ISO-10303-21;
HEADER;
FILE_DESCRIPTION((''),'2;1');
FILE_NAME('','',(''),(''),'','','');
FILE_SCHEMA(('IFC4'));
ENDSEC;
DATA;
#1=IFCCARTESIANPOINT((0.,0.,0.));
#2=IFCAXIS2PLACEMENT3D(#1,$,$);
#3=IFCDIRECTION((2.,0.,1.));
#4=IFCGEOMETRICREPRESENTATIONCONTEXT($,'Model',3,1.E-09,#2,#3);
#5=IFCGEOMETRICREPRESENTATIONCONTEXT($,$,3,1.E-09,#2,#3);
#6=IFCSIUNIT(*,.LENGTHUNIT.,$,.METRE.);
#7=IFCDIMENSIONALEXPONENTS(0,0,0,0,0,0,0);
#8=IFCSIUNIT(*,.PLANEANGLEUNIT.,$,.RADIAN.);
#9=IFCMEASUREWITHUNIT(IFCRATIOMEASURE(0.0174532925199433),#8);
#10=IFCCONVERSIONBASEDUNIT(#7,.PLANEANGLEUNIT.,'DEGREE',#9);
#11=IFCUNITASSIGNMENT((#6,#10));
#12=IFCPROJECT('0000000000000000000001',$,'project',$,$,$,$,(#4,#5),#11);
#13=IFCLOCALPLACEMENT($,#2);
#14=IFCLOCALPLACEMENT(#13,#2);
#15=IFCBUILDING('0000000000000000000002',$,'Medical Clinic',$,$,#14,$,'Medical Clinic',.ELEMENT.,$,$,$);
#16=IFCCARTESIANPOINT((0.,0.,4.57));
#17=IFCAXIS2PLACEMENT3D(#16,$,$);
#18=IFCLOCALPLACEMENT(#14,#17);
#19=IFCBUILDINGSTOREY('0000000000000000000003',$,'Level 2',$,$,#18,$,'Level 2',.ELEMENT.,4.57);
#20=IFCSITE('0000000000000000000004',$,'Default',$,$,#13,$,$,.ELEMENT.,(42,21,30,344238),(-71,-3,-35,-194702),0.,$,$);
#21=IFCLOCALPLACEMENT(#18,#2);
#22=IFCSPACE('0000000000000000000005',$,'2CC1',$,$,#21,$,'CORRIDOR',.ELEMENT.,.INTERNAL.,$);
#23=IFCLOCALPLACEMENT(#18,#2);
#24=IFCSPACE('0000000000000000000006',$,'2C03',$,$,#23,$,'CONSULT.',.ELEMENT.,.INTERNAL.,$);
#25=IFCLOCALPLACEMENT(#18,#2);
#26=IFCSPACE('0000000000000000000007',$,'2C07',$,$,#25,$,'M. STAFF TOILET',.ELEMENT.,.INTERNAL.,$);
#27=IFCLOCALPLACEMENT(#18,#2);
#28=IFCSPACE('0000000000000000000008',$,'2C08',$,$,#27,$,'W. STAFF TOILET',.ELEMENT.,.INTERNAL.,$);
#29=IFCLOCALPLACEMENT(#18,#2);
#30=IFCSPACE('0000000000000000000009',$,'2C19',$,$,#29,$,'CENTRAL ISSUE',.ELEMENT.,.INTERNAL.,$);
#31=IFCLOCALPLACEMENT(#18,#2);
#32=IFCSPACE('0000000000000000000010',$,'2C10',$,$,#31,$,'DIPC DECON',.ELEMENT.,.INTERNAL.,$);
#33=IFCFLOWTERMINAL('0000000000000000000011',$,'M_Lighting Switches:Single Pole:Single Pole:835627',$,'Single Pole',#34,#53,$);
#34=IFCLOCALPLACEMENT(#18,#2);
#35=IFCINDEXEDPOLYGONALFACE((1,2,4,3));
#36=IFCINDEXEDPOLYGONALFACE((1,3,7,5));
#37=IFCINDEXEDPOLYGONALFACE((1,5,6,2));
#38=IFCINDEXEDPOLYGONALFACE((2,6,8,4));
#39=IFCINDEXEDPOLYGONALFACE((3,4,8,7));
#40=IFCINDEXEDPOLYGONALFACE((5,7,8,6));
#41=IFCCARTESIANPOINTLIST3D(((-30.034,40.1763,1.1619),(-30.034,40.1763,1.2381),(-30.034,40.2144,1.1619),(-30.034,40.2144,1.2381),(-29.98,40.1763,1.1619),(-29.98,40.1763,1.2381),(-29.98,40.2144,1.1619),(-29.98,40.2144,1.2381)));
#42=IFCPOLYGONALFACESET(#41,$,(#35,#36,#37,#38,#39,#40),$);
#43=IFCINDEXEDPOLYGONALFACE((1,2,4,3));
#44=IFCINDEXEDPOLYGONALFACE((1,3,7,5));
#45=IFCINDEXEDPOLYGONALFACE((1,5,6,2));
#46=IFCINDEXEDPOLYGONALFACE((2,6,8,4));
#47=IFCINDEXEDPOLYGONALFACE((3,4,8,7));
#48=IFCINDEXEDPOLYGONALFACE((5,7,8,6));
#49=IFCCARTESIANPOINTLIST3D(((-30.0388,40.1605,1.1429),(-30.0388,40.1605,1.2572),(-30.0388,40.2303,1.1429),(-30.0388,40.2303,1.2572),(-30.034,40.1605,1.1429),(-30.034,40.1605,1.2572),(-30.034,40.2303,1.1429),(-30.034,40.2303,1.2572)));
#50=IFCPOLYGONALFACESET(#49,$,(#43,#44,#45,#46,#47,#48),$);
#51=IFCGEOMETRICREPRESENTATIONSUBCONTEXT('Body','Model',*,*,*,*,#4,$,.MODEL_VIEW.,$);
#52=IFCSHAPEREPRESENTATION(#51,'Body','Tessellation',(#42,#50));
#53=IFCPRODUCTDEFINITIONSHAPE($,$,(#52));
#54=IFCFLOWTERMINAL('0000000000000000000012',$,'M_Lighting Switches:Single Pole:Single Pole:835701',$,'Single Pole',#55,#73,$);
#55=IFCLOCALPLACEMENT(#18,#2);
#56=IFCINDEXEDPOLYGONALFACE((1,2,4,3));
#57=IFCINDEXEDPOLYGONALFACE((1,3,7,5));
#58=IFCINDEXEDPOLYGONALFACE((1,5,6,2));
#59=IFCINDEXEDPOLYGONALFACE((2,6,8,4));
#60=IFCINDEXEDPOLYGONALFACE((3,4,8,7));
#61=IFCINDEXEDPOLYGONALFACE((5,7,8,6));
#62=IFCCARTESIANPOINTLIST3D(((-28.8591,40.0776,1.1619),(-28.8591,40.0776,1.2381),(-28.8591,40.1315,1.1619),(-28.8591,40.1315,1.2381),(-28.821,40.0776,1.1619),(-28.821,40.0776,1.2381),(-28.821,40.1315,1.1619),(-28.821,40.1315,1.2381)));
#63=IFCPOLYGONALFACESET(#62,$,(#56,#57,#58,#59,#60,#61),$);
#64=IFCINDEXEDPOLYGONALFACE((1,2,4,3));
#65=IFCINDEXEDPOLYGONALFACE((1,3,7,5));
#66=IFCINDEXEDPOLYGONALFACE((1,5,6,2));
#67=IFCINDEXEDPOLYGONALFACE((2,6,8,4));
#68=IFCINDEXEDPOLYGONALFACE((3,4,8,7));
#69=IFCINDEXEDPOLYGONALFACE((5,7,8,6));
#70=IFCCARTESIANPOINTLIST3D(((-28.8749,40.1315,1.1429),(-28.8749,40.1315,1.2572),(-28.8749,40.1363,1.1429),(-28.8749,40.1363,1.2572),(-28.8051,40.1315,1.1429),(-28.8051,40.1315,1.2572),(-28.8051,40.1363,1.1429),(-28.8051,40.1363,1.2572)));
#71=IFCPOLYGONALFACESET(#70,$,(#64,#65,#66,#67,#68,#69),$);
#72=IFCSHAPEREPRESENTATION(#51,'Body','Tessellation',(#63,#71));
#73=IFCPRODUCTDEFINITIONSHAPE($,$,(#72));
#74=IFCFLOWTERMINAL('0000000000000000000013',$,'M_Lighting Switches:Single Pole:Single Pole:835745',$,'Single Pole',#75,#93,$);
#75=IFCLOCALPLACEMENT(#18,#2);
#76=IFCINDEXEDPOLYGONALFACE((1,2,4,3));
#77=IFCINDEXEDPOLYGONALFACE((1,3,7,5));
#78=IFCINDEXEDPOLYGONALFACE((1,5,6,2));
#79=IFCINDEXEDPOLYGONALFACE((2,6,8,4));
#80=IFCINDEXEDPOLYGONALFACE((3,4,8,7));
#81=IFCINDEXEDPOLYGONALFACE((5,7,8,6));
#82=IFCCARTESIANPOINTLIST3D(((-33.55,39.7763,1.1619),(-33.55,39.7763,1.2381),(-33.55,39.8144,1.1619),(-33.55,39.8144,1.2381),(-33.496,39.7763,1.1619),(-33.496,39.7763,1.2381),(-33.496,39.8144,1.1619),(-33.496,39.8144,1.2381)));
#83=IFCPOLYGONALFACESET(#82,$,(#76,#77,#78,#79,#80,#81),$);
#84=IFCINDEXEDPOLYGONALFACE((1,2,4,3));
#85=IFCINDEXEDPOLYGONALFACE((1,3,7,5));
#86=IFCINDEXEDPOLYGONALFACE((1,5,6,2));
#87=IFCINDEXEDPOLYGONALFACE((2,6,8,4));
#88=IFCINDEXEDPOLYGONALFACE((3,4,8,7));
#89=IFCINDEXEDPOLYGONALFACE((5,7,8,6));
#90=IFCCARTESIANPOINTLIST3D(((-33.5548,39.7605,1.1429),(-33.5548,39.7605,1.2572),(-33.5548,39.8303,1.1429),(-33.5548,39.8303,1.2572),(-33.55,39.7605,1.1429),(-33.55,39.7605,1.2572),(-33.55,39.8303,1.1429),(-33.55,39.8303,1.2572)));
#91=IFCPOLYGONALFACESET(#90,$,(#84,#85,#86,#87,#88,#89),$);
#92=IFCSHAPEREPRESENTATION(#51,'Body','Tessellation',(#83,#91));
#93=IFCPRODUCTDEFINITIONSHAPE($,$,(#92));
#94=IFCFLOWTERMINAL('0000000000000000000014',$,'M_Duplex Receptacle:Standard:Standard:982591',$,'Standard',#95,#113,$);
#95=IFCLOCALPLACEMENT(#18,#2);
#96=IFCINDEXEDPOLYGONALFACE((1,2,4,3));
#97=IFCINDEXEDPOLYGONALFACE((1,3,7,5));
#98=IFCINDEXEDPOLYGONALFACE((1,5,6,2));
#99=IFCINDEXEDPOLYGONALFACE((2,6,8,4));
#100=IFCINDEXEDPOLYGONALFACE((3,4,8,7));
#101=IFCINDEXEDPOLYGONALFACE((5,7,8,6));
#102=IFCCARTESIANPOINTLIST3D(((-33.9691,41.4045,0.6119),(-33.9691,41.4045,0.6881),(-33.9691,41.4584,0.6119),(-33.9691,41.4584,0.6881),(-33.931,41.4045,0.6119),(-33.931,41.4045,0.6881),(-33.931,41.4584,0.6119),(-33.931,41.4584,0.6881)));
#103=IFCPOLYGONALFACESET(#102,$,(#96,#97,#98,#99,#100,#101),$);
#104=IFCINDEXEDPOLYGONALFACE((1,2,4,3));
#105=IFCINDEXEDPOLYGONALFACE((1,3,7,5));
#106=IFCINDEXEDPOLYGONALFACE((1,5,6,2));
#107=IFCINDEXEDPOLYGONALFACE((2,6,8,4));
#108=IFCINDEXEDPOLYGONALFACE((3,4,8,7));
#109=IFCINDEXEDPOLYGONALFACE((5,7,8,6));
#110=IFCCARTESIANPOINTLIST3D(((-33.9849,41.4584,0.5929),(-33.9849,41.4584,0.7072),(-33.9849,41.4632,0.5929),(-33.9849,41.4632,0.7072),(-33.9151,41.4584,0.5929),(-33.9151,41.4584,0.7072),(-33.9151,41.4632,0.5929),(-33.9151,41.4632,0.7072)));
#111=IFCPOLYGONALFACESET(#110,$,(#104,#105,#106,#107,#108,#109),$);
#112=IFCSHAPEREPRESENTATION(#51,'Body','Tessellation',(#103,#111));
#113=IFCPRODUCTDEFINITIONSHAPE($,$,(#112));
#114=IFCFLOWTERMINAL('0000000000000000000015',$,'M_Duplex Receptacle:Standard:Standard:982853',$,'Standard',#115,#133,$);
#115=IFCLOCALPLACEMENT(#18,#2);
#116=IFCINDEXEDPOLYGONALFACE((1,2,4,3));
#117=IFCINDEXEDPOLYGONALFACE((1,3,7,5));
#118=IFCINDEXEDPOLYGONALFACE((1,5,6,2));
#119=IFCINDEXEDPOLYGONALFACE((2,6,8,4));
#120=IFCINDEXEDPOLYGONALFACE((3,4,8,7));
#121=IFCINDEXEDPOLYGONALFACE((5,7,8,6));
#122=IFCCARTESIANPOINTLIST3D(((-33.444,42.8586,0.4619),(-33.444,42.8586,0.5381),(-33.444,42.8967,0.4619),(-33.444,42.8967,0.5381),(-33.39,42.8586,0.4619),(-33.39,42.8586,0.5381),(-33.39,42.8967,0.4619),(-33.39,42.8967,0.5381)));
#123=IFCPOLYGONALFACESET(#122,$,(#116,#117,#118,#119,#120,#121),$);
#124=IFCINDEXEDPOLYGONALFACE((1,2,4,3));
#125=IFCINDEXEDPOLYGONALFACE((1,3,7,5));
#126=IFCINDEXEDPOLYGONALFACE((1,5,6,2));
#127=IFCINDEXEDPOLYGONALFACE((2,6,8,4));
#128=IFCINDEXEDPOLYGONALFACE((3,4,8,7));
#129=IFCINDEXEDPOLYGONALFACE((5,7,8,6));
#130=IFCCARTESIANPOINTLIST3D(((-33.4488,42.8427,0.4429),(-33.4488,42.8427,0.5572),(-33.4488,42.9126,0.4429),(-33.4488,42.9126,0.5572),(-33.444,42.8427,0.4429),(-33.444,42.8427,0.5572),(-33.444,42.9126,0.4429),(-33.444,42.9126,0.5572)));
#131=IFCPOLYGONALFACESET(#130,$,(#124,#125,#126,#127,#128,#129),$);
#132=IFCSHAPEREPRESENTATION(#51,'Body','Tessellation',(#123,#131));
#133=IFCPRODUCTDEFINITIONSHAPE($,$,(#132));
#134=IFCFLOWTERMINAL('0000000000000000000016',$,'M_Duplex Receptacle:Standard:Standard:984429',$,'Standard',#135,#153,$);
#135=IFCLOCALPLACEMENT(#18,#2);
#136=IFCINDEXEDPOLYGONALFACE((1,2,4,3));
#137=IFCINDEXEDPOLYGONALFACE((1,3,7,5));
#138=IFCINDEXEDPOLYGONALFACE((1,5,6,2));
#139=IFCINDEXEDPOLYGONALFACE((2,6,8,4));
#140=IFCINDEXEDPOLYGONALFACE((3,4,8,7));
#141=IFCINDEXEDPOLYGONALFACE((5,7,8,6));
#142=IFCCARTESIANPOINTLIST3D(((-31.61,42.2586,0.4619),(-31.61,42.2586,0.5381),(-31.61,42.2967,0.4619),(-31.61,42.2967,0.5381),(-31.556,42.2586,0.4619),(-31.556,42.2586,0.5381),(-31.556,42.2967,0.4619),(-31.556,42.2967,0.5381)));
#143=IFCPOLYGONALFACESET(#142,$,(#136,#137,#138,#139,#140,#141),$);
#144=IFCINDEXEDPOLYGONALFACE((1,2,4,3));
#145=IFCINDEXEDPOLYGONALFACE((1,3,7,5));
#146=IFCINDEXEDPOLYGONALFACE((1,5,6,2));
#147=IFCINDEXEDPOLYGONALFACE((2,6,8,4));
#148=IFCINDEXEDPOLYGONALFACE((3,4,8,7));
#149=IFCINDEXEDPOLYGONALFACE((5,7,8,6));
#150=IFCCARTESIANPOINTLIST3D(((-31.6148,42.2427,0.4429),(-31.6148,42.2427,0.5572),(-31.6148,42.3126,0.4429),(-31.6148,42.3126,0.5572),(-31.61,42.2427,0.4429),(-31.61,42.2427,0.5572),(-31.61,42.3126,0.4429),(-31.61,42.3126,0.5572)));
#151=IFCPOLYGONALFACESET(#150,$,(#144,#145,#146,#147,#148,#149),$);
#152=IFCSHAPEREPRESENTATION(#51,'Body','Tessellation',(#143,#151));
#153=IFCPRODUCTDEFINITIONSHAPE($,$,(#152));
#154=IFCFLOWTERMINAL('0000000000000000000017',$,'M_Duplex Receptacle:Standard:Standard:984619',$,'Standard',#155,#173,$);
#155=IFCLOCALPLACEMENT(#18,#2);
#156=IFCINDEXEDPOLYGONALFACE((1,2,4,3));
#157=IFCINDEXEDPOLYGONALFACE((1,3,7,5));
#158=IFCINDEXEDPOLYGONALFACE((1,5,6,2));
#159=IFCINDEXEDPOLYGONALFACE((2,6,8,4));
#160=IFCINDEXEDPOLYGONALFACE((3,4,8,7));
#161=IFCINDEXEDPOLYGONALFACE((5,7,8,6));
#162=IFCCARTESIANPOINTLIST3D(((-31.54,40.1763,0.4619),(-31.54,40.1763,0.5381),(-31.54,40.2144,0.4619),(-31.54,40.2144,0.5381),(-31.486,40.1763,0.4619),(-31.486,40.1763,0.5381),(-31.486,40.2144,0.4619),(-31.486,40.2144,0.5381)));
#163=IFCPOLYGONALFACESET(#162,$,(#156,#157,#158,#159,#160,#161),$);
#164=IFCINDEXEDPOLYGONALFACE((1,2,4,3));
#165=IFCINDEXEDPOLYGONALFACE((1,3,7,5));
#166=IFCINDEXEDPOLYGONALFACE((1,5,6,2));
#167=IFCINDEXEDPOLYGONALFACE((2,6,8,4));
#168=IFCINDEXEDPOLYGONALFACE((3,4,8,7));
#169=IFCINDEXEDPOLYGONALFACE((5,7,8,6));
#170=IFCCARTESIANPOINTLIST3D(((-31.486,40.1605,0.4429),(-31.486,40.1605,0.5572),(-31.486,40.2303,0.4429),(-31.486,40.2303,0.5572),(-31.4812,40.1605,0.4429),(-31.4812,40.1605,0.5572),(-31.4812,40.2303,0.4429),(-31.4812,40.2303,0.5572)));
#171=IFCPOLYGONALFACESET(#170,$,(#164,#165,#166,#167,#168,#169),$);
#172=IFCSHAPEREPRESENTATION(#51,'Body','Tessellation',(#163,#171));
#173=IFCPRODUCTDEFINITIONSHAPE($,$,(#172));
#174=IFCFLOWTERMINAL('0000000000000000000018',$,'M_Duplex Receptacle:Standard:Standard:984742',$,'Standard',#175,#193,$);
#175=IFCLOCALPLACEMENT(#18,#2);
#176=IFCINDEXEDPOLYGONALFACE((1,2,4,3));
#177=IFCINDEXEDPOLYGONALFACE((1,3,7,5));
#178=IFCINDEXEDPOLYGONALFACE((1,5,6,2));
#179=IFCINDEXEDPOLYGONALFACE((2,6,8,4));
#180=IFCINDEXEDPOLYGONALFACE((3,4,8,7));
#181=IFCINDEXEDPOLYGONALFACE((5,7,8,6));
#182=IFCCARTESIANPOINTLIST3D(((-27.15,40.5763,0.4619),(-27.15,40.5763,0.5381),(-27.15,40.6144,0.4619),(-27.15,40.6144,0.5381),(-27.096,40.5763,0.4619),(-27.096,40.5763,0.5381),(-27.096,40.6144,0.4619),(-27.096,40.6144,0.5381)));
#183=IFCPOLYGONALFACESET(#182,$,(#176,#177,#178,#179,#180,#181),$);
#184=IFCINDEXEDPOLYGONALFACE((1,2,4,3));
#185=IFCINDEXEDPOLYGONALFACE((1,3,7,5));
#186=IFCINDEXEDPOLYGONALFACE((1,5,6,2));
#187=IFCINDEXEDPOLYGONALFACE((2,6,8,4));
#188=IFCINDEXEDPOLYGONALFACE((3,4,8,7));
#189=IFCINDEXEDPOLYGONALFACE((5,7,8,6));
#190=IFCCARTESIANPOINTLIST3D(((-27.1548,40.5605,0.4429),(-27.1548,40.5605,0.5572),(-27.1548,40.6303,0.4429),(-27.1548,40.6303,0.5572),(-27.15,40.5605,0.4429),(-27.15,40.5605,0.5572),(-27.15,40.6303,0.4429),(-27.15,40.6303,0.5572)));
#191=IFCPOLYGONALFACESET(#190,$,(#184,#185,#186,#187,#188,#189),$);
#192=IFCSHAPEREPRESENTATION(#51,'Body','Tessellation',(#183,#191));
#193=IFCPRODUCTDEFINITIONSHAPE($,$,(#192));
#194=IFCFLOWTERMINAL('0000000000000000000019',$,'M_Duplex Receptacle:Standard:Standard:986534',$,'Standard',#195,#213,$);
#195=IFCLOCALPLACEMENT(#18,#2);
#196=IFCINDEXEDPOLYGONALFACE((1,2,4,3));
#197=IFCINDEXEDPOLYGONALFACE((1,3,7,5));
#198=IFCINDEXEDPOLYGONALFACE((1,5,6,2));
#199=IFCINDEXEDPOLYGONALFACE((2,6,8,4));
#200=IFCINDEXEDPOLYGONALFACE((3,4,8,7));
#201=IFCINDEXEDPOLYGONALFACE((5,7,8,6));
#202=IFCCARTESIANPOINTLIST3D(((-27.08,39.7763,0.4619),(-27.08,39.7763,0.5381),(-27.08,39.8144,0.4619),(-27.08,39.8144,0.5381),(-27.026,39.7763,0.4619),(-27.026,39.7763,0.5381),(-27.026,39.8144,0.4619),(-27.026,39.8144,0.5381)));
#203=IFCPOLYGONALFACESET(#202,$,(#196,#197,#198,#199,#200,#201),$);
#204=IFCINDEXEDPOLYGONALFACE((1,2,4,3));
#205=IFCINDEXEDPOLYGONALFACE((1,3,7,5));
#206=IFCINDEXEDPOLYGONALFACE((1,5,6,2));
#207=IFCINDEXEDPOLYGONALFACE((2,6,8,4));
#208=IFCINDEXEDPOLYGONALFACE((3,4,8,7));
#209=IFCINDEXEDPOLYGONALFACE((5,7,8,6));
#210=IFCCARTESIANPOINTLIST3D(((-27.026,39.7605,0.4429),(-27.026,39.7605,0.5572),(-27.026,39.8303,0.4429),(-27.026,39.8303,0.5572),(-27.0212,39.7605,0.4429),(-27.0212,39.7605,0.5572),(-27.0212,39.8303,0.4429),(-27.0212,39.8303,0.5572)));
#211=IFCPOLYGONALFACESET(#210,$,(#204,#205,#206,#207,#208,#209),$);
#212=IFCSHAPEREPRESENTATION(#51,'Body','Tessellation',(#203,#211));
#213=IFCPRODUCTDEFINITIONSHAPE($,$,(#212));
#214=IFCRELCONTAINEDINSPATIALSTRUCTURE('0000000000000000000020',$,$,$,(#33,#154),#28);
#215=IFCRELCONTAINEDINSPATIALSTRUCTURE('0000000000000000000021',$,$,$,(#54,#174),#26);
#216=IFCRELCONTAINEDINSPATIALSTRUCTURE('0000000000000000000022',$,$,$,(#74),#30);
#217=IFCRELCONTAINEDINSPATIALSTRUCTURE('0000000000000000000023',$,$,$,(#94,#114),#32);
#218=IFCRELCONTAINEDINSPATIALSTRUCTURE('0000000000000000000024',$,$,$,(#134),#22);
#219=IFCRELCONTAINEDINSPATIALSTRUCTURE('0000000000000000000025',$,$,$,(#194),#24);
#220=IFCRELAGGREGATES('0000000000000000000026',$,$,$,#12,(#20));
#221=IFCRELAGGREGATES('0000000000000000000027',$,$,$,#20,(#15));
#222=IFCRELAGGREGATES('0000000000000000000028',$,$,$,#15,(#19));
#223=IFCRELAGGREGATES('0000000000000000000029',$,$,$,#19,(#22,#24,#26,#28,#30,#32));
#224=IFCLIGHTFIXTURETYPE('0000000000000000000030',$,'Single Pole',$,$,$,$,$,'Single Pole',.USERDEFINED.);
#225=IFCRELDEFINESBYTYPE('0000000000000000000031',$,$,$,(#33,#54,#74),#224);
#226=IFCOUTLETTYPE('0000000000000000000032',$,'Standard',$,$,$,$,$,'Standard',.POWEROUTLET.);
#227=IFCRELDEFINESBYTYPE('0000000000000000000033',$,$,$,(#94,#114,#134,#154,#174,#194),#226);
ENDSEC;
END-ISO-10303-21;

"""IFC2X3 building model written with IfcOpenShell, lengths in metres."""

from ifc_helpers import new_model, entity, si_unit, converted_unit, direction, frame, frame_2d, origin, origin_2d_with_axis, place, context, subcontext, project, spatial, rectangle, extrude, source, transform, mapped, type_object, type_shapes, element, save


model = new_model("IFC2X3")

# Units and contexts
model_context = context("Model", 3, precision=1e-09, world=origin(), true_north=direction((2.0, 0.0, 1.0)))
context_of_model = context(None, 3, precision=1e-09, world=origin(), true_north=direction((2.0, 0.0, 1.0)))
body_context = subcontext(model_context, "Body", "Model", "MODEL_VIEW")
ifc_project = project(units=[si_unit("LENGTHUNIT", "METRE"), converted_unit("PLANEANGLEUNIT", "DEGREE", entity("IfcRatioMeasure", 0.0174532925199433), si_unit("PLANEANGLEUNIT", "RADIAN"), dimensions=[0, 0, 0, 0, 0, 0, 0])], contexts=[model_context, context_of_model])

# Site, building, storey, space
site_placement = place(None, origin())
site = spatial("IfcSite", under=ifc_project, at=site_placement, Name="Default", CompositionType="ELEMENT", RefLatitude=(42, 21, 30, 344238), RefLongitude=(-71, -3, -35, -194702), RefElevation=0.0)
building_placement = place(site_placement, origin())
building = spatial("IfcBuilding", under=site, at=building_placement, Name="Medical Clinic", LongName="Medical Clinic", CompositionType="ELEMENT")
storey_placement = place(building_placement, frame((0.0, 0.0, 4.57)))
storey = spatial("IfcBuildingStorey", under=building, at=storey_placement, Name="Level 2", LongName="Level 2", CompositionType="ELEMENT", Elevation=4.57)
space_1_placement = place(storey_placement, origin())
space_1 = spatial("IfcSpace", under=storey, at=space_1_placement, Name="2CC1", LongName="CORRIDOR", CompositionType="ELEMENT", InteriorOrExteriorSpace="INTERNAL")

# Shared definitions
space_2_placement = place(storey_placement, origin())
space_2 = spatial("IfcSpace", under=storey, at=space_2_placement, Name="2C03", LongName="CONSULT.", CompositionType="ELEMENT", InteriorOrExteriorSpace="INTERNAL")

# Shared definitions
space_3_placement = place(storey_placement, origin())
space_3 = spatial("IfcSpace", under=storey, at=space_3_placement, Name="2C07", LongName="M. STAFF TOILET", CompositionType="ELEMENT", InteriorOrExteriorSpace="INTERNAL")

# Shared definitions
space_4_placement = place(storey_placement, origin())
space_4 = spatial("IfcSpace", under=storey, at=space_4_placement, Name="2C08", LongName="W. STAFF TOILET", CompositionType="ELEMENT", InteriorOrExteriorSpace="INTERNAL")

# Flow terminals
light_fixture_type_1 = type_object("IfcLightFixtureType", Name="Single Pole", ElementType="Single Pole", PredefinedType="USERDEFINED")
shared_shape_1 = source(origin(), body_context, "Body", "SweptSolid", [
    extrude(rectangle(XDim=0.0381, YDim=0.0762, at=origin_2d_with_axis()), frame((0.0, 0.0, -0.054), z_axis=(0.0, 0.0, 1.0), x_axis=(-1.0, 0.0, 0.0)), (0.0, 0.0, 1.0), 0.054),
    extrude(rectangle(XDim=0.0698, YDim=0.1143, at=frame_2d((0.0, 0.0), x_axis=(1.0, 0.0))), frame((0.0, 0.0, 0.0), z_axis=(0.0, 0.0, 1.0), x_axis=(-1.0, 0.0, 0.0)), (0.0, 0.0, 1.0), 0.0048),
])
type_shapes(light_fixture_type_1, [shared_shape_1])
flow_terminal_1_placement = place(space_4_placement, frame((-30.034, 40.1954, 1.2), z_axis=(-1.0, 0.0, 0.0), x_axis=(0.0, -1.0, 0.0)))
element("IfcFlowTerminal", 1, at=flow_terminal_1_placement, inside=space_4, type_object=light_fixture_type_1, Name="M_Lighting Switches:Single Pole:Single Pole:835627", ObjectType="Single Pole", context=body_context, shape_type="MappedRepresentation", body=[
    mapped(shared_shape_1, transform((0.0, 0.0, 0.0), scale=1.0)),
])
flow_terminal_2_placement = place(space_3_placement, frame((-28.84, 40.1315, 1.2), z_axis=(0.0, 1.0, 0.0), x_axis=(-1.0, 0.0, 0.0)))
element("IfcFlowTerminal", 2, at=flow_terminal_2_placement, inside=space_3, type_object=light_fixture_type_1, Name="M_Lighting Switches:Single Pole:Single Pole:835701", ObjectType="Single Pole", context=body_context, shape_type="MappedRepresentation", body=[
    mapped(shared_shape_1, transform((0.0, 0.0, 0.0), scale=1.0)),
])

# Shared definitions
space_5_placement = place(storey_placement, origin())
space_5 = spatial("IfcSpace", under=storey, at=space_5_placement, Name="2C19", LongName="CENTRAL ISSUE", CompositionType="ELEMENT", InteriorOrExteriorSpace="INTERNAL")

# Flow terminal
flow_terminal_3_placement = place(space_5_placement, frame((-33.55, 39.7954, 1.2), z_axis=(-1.0, 0.0, 0.0), x_axis=(0.0, -1.0, 0.0)))
element("IfcFlowTerminal", 3, at=flow_terminal_3_placement, inside=space_5, type_object=light_fixture_type_1, Name="M_Lighting Switches:Single Pole:Single Pole:835745", ObjectType="Single Pole", context=body_context, shape_type="MappedRepresentation", body=[
    mapped(shared_shape_1, transform((0.0, 0.0, 0.0), scale=1.0)),
])

# Shared definitions
space_6_placement = place(storey_placement, origin())
space_6 = spatial("IfcSpace", under=storey, at=space_6_placement, Name="2C10", LongName="DIPC DECON", CompositionType="ELEMENT", InteriorOrExteriorSpace="INTERNAL")

# Flow terminals
outlet_type = type_object("IfcOutletType", Name="Standard", ElementType="Standard", PredefinedType="POWEROUTLET")
shared_shape_2 = source(origin(), body_context, "Body", "SweptSolid", [
    extrude(rectangle(XDim=0.0381, YDim=0.0762, at=origin_2d_with_axis()), frame((0.0, 0.0, -0.054), z_axis=(0.0, 0.0, 1.0), x_axis=(-1.0, 0.0, 0.0)), (0.0, 0.0, 1.0), 0.054),
    extrude(rectangle(XDim=0.0698, YDim=0.1143, at=frame_2d((0.0, 0.0), x_axis=(1.0, 0.0))), frame((0.0, 0.0, 0.0), z_axis=(0.0, 0.0, 1.0), x_axis=(-1.0, 0.0, 0.0)), (0.0, 0.0, 1.0), 0.0048),
])
type_shapes(outlet_type, [shared_shape_2])
for number, where, z_axis, x_axis, name in (
    (4, (-33.95, 41.4584, 0.65), (0.0, 1.0, 0.0), (-1.0, 0.0, 0.0), "M_Duplex Receptacle:Standard:Standard:982591"),
    (5, (-33.444, 42.8776, 0.5), (-1.0, 0.0, 0.0), (0.0, -1.0, 0.0), "M_Duplex Receptacle:Standard:Standard:982853"),
):
    element("IfcFlowTerminal", number, at=place(space_6_placement, frame(where, z_axis=z_axis, x_axis=x_axis)), inside=space_6, type_object=outlet_type, Name=name, ObjectType="Standard", context=body_context, shape_type="MappedRepresentation", body=[
        mapped(shared_shape_2, transform((0.0, 0.0, 0.0), scale=1.0)),
    ])
flow_terminal_4_placement = place(space_1_placement, frame((-31.61, 42.2776, 0.5), z_axis=(-1.0, 0.0, 0.0), x_axis=(0.0, -1.0, 0.0)))
element("IfcFlowTerminal", 6, at=flow_terminal_4_placement, inside=space_1, type_object=outlet_type, Name="M_Duplex Receptacle:Standard:Standard:984429", ObjectType="Standard", context=body_context, shape_type="MappedRepresentation", body=[
    mapped(shared_shape_2, transform((0.0, 0.0, 0.0), scale=1.0)),
])
flow_terminal_5_placement = place(space_4_placement, frame((-31.486, 40.1954, 0.5), z_axis=(1.0, 0.0, 0.0), x_axis=(0.0, 1.0, 0.0)))
element("IfcFlowTerminal", 7, at=flow_terminal_5_placement, inside=space_4, type_object=outlet_type, Name="M_Duplex Receptacle:Standard:Standard:984619", ObjectType="Standard", context=body_context, shape_type="MappedRepresentation", body=[
    mapped(shared_shape_2, transform((0.0, 0.0, 0.0), scale=1.0)),
])
flow_terminal_6_placement = place(space_3_placement, frame((-27.15, 40.5954, 0.5), z_axis=(-1.0, 0.0, 0.0), x_axis=(0.0, -1.0, 0.0)))
element("IfcFlowTerminal", 8, at=flow_terminal_6_placement, inside=space_3, type_object=outlet_type, Name="M_Duplex Receptacle:Standard:Standard:984742", ObjectType="Standard", context=body_context, shape_type="MappedRepresentation", body=[
    mapped(shared_shape_2, transform((0.0, 0.0, 0.0), scale=1.0)),
])
for number, where, z_axis, x_axis, name in (
    (9, (-27.026, 39.7954, 0.5), (1.0, 0.0, 0.0), (0.0, 1.0, 0.0), "M_Duplex Receptacle:Standard:Standard:986534"),
):
    element("IfcFlowTerminal", number, at=place(space_2_placement, frame(where, z_axis=z_axis, x_axis=x_axis)), inside=space_2, type_object=outlet_type, Name=name, ObjectType="Standard", context=body_context, shape_type="MappedRepresentation", body=[
        mapped(shared_shape_2, transform((0.0, 0.0, 0.0), scale=1.0)),
    ])

save(model, "model.ifc")
